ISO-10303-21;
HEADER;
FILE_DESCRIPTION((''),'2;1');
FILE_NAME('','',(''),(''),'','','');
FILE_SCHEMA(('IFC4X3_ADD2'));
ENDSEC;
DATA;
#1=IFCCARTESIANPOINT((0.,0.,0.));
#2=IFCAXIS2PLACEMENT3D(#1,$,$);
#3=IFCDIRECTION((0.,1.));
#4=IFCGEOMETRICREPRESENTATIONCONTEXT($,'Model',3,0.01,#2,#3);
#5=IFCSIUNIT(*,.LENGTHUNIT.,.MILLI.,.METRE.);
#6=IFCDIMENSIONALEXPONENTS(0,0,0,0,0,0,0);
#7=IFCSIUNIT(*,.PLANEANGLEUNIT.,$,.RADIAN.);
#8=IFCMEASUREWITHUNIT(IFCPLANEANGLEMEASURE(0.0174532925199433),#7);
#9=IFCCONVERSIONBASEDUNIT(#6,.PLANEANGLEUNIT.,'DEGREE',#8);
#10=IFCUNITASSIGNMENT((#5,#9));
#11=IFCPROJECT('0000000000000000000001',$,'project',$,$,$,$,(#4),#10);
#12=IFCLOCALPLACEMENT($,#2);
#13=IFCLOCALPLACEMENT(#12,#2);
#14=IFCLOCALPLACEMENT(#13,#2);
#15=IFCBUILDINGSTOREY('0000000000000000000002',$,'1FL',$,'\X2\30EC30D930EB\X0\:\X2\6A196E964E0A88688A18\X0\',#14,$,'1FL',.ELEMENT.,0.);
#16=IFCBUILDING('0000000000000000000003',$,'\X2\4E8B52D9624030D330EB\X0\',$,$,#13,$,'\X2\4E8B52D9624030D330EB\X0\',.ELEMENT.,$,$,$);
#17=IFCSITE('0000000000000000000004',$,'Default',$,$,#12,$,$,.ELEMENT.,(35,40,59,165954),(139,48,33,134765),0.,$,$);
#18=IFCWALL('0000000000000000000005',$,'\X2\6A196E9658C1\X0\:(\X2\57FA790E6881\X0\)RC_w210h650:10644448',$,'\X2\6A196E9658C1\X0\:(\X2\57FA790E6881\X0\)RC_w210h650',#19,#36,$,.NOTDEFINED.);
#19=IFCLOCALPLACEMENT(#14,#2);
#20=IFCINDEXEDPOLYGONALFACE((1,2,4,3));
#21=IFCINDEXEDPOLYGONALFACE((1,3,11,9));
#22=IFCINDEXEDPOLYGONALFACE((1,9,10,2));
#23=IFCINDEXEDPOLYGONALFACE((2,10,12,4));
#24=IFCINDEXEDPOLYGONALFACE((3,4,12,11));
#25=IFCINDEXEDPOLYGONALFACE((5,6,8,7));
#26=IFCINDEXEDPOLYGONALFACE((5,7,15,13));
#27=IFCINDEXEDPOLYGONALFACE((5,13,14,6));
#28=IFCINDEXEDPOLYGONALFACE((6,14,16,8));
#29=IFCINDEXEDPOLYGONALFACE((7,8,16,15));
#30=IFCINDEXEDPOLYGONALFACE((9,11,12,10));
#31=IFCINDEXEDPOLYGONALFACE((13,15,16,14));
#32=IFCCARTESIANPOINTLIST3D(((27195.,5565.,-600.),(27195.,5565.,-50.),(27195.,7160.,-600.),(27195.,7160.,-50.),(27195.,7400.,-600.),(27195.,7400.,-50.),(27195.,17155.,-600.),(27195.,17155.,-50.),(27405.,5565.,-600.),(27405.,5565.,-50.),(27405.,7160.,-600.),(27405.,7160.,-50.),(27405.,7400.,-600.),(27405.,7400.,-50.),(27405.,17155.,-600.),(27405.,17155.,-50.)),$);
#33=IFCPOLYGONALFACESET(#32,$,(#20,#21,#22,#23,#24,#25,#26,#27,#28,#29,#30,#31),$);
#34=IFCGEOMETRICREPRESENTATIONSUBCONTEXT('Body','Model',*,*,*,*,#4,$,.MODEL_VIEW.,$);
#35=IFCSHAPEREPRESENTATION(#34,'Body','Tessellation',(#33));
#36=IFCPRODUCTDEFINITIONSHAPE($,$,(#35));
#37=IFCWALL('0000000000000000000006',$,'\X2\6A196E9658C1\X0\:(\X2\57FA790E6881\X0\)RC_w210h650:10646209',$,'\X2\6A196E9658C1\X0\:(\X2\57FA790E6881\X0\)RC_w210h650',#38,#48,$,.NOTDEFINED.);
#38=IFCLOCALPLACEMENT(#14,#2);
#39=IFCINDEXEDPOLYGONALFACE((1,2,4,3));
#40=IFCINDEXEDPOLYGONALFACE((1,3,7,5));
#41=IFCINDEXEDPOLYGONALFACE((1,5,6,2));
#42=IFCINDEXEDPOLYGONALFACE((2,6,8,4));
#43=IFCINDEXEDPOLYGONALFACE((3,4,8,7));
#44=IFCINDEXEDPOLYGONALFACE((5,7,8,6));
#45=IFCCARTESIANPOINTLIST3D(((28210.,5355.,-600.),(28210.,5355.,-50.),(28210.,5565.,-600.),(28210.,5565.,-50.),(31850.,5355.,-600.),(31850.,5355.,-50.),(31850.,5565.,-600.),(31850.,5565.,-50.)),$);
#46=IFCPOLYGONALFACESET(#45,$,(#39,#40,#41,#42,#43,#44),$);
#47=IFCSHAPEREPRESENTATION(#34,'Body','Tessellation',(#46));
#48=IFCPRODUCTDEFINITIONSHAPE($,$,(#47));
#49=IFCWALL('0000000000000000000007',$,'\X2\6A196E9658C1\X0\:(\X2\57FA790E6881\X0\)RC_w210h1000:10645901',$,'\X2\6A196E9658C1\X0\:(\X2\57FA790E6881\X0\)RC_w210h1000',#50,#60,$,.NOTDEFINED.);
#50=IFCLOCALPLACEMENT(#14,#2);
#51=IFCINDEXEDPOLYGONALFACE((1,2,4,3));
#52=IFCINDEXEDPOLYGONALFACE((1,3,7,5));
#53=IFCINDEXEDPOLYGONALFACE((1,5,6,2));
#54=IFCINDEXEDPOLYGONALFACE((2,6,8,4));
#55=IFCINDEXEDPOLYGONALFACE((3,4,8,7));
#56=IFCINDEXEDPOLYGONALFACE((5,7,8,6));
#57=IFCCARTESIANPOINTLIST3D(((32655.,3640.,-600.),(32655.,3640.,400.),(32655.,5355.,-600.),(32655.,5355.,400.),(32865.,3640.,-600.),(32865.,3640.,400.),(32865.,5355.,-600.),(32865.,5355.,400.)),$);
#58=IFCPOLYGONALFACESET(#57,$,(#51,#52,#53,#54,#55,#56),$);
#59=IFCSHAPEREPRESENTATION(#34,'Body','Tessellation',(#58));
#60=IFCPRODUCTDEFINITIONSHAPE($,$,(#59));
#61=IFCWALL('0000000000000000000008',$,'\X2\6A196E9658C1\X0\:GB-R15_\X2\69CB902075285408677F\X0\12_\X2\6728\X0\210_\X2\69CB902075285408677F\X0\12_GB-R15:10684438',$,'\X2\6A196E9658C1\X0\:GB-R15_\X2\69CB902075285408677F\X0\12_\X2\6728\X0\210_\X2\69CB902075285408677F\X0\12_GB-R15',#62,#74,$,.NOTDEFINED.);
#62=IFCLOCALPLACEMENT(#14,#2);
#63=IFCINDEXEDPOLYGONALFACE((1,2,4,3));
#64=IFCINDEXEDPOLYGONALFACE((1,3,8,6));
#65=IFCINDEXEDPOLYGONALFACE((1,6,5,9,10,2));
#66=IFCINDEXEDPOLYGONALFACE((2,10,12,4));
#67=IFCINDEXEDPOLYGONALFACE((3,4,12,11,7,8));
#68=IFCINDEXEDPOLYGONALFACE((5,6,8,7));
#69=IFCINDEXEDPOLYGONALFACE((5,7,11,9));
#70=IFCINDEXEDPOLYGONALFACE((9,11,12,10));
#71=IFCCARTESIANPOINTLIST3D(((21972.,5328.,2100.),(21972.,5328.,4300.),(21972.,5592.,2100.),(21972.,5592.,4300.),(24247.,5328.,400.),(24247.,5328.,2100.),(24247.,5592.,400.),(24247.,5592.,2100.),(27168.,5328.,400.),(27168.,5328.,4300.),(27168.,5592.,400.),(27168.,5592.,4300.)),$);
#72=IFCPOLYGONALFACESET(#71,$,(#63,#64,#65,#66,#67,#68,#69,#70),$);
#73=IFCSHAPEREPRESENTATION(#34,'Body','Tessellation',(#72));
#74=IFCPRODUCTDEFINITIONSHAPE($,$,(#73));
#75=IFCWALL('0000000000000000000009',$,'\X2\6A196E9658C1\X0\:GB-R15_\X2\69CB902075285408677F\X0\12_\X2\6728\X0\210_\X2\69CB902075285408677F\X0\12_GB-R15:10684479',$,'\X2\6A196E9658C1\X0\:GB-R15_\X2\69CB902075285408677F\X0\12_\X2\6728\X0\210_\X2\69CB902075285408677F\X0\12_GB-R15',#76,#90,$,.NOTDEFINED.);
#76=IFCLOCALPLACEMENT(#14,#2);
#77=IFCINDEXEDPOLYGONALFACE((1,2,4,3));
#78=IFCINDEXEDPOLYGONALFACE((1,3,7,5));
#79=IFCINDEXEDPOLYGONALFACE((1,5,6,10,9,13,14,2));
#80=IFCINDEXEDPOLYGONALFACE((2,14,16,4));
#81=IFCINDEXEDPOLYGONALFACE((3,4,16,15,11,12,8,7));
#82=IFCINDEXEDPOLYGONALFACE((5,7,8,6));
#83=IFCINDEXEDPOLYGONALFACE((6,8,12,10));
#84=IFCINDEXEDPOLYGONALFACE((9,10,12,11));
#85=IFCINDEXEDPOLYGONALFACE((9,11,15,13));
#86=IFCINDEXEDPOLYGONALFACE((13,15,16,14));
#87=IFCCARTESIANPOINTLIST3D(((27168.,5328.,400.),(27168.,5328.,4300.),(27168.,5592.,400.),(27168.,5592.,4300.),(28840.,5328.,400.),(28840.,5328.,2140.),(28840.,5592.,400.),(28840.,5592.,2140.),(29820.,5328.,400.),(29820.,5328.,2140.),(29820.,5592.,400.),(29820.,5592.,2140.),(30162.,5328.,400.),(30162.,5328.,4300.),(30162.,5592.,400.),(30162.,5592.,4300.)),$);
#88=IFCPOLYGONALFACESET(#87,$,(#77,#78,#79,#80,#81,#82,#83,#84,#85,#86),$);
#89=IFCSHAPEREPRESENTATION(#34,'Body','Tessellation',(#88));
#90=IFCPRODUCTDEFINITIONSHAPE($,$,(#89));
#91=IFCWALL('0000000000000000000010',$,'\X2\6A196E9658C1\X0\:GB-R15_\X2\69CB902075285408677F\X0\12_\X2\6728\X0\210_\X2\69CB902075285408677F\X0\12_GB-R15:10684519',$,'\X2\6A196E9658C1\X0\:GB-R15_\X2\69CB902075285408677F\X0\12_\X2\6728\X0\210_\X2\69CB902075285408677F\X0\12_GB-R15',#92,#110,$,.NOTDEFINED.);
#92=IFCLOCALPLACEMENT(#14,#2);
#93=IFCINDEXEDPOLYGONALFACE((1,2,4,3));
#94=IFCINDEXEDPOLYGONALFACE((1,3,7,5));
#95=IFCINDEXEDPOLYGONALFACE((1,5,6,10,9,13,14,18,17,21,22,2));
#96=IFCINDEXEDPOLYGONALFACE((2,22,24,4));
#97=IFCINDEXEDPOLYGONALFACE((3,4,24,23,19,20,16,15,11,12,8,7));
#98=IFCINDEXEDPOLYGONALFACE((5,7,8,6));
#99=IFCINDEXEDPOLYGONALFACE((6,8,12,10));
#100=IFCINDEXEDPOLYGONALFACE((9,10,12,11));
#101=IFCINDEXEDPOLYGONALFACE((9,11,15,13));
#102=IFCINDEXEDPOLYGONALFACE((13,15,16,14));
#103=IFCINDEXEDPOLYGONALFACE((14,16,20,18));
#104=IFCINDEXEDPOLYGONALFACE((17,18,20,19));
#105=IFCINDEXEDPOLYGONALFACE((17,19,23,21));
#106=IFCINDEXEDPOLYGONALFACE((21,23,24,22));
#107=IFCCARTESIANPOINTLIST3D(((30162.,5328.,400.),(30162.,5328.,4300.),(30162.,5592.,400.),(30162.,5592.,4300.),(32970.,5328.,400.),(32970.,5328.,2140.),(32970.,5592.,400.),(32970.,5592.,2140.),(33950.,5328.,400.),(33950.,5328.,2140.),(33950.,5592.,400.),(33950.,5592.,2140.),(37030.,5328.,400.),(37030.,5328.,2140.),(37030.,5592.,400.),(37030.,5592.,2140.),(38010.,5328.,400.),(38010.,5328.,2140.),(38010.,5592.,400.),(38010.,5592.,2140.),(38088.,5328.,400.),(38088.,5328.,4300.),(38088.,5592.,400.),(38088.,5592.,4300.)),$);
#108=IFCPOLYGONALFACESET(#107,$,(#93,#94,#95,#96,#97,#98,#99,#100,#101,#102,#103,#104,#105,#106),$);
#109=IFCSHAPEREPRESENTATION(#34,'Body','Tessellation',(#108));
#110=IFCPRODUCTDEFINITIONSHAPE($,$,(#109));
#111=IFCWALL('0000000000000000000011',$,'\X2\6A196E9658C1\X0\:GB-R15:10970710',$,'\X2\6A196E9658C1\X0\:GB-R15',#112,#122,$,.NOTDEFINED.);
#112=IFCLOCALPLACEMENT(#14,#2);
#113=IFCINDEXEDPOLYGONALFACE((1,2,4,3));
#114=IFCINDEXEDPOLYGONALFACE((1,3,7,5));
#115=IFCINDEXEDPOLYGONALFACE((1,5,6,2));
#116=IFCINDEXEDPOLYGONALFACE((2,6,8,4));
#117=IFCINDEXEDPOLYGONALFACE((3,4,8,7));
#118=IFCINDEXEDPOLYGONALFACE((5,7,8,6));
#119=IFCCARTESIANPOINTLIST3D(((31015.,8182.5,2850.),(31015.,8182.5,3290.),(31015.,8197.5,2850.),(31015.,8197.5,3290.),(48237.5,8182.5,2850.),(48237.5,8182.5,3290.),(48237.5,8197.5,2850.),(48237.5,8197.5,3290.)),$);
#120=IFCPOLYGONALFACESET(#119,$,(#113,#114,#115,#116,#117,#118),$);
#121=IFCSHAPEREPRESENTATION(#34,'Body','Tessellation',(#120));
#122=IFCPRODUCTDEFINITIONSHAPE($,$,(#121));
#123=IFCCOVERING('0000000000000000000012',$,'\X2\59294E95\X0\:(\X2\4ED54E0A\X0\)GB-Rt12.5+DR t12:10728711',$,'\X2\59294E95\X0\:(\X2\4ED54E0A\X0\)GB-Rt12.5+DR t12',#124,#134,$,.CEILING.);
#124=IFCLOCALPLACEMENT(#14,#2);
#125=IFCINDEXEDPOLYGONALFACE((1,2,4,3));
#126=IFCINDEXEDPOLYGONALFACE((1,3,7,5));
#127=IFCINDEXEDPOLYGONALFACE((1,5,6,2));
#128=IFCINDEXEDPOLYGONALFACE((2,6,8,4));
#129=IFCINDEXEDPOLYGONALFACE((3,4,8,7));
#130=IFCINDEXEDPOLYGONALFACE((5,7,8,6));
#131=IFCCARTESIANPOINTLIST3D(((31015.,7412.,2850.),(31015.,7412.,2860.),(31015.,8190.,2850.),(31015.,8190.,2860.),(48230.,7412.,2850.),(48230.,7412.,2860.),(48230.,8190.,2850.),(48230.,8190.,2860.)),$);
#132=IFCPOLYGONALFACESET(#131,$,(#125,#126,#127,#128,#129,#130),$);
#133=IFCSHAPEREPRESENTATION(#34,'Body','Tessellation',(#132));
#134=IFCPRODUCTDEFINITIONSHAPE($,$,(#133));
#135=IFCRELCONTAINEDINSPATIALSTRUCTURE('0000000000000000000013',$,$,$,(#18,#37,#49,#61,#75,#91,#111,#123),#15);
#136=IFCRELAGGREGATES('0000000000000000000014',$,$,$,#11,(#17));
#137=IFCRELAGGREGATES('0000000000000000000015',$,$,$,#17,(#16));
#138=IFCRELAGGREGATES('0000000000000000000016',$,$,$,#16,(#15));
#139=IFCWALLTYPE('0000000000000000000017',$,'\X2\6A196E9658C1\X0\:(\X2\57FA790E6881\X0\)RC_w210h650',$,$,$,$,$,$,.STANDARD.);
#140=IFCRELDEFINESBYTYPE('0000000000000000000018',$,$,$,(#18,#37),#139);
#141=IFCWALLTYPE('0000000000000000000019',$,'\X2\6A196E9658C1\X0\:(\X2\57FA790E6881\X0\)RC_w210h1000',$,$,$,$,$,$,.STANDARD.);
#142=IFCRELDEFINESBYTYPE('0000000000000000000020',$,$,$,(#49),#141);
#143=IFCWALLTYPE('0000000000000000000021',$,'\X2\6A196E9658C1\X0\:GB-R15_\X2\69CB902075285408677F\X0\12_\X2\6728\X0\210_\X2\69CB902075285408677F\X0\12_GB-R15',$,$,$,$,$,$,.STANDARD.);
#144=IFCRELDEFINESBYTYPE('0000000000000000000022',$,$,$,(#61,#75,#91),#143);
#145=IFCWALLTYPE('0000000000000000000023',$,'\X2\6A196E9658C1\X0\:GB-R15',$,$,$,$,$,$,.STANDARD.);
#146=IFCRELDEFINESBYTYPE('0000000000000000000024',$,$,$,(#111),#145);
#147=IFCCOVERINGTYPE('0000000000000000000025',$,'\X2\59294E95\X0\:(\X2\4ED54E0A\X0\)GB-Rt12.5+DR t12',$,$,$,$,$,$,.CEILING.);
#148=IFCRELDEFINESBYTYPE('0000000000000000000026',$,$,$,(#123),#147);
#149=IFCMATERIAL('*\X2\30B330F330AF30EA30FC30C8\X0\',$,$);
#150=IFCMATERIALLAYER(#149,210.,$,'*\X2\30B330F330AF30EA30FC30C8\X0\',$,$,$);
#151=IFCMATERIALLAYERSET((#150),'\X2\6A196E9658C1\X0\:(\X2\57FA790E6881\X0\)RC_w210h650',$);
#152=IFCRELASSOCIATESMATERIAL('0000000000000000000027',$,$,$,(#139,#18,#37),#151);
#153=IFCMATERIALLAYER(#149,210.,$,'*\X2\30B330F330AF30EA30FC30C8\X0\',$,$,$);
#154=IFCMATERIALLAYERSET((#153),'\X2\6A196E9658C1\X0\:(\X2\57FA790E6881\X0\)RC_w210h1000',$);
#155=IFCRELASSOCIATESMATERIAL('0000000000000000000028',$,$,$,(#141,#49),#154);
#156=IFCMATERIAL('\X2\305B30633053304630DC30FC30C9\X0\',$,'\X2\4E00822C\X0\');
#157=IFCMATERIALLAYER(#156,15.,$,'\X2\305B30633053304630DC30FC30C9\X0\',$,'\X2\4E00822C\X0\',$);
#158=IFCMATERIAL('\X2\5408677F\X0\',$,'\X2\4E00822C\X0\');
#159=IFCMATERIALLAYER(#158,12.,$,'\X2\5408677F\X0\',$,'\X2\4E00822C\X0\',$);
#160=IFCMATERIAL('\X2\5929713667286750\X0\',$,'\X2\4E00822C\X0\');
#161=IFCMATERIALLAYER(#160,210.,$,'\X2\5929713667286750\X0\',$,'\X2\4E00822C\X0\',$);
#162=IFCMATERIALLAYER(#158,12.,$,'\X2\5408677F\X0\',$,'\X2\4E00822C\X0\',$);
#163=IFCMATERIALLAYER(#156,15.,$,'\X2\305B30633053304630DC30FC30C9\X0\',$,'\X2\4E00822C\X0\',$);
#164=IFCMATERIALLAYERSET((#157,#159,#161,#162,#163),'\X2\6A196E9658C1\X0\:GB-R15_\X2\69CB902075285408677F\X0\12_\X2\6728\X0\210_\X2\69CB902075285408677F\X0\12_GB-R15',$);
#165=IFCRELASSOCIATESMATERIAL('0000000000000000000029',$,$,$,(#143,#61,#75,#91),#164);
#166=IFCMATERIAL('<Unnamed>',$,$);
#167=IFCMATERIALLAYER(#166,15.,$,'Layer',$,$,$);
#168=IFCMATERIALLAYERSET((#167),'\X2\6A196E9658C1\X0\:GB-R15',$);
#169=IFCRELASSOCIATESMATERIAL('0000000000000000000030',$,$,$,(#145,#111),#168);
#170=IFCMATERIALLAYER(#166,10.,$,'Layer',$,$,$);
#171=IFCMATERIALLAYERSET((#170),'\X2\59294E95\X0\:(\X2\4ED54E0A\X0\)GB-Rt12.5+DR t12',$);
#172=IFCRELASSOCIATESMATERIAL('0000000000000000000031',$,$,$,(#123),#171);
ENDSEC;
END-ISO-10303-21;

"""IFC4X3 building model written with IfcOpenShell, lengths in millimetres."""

from ifc_helpers import new_model, entity, si_unit, converted_unit, direction, frame, frame_2d, origin, place, context, subcontext, project, spatial, rectangle, extrude, material, layer, layer_set, layer_usage, type_object, element, save


model = new_model("IFC4X3")

# Units and contexts
model_context = context("Model", 3, precision=0.01, world=origin(), true_north=direction((0.0, 1.0)))
body_context = subcontext(model_context, "Body", "Model", "MODEL_VIEW")
ifc_project = project(units=[si_unit("LENGTHUNIT", "METRE", prefix="MILLI"), converted_unit("PLANEANGLEUNIT", "DEGREE", entity("IfcPlaneAngleMeasure", 0.0174532925199433), si_unit("PLANEANGLEUNIT", "RADIAN"), dimensions=[0, 0, 0, 0, 0, 0, 0])], contexts=[model_context])

# Site, building, storey
site_placement = place(None, origin())
site = spatial("IfcSite", under=ifc_project, at=site_placement, Name="Default", CompositionType="ELEMENT", RefLatitude=(35, 40, 59, 165954), RefLongitude=(139, 48, 33, 134765), RefElevation=0.0)
building_placement = place(site_placement, origin())
building = spatial("IfcBuilding", under=site, at=building_placement, Name="事務所ビル", LongName="事務所ビル", CompositionType="ELEMENT")
storey_placement = place(building_placement, origin())
storey = spatial("IfcBuildingStorey", under=building, at=storey_placement, Name="1FL", ObjectType="レベル:標準上表記", LongName="1FL", CompositionType="ELEMENT", Elevation=0.0)

# Shared definitions
ifc_material_1 = material(Name="*コンクリート")
ifc_material_2 = material(Name="<Unnamed>")

# Wall, opening
ifc_layer_1 = layer(ifc_material_1, 210.0, Name="*コンクリート")
ifc_layer_set_1 = layer_set([ifc_layer_1], Name="標準壁:(基礎梁)RC_w210h650")
wall_type_1 = type_object("IfcWallType", Name="標準壁:(基礎梁)RC_w210h650", PredefinedType="STANDARD", material=ifc_layer_set_1)
wall_1_placement = place(storey_placement, frame((27300.0, 5565.0, -600.0), z_axis=(0.0, 0.0, 1.0), x_axis=(0.0, 1.0, 0.0)))
wall_1 = element("IfcWall", 1, at=wall_1_placement, inside=storey, type_object=wall_type_1, material=ifc_layer_set_1, Name="標準壁:(基礎梁)RC_w210h650:10644448", ObjectType="標準壁:(基礎梁)RC_w210h650", PredefinedType="NOTDEFINED", context=body_context, shape_type="SweptSolid", body=[
    extrude(rectangle(XDim=11590.0, YDim=210.0, at=frame_2d((5795.0, 0.0), x_axis=(-1.0, 0.0))), origin(), (0.0, 0.0, 1.0), 550.0),
])
opening_1_placement = place(storey_placement, frame((27300.0, 5565.0, -600.0), z_axis=(0.0, 0.0, 1.0), x_axis=(0.0, 1.0, 0.0)))
element("IfcOpeningElement", 2, at=opening_1_placement, cuts=wall_1, PredefinedType="OPENING", context=body_context, shape_type="SweptSolid", body=[
    extrude(rectangle(XDim=550.0, YDim=210.0, at=frame_2d((0.0, 0.0), x_axis=(1.0, 0.0))), frame((1595.0, 0.0, 275.0), z_axis=(1.0, 0.0, 0.0), x_axis=(0.0, 0.0, -1.0)), (0.0, 0.0, 1.0), 240.0),
])

# Wall
wall_2_placement = place(storey_placement, frame((28210.0, 5460.0, -600.0)))
element("IfcWall", 3, at=wall_2_placement, inside=storey, type_object=wall_type_1, material=ifc_layer_set_1, Name="標準壁:(基礎梁)RC_w210h650:10646209", ObjectType="標準壁:(基礎梁)RC_w210h650", PredefinedType="NOTDEFINED", context=body_context, shape_type="SweptSolid", body=[
    extrude(rectangle(XDim=3640.0, YDim=210.0, at=frame_2d((1820.0, 0.0), x_axis=(-1.0, 0.0))), origin(), (0.0, 0.0, 1.0), 550.0),
])

# Shared definitions
ifc_layer_2 = layer(ifc_material_1, 210.0, Name="*コンクリート")
ifc_layer_set_2 = layer_set([ifc_layer_2], Name="標準壁:(基礎梁)RC_w210h1000")
wall_type_2 = type_object("IfcWallType", Name="標準壁:(基礎梁)RC_w210h1000", PredefinedType="STANDARD", material=ifc_layer_set_2)

# Wall
wall_3_placement = place(storey_placement, frame((32760.0, 5355.0, -600.0), z_axis=(0.0, 0.0, 1.0), x_axis=(0.0, -1.0, 0.0)))
element("IfcWall", 4, at=wall_3_placement, inside=storey, type_object=wall_type_2, material=ifc_layer_set_2, Name="標準壁:(基礎梁)RC_w210h1000:10645901", ObjectType="標準壁:(基礎梁)RC_w210h1000", PredefinedType="NOTDEFINED", context=body_context, shape_type="SweptSolid", body=[
    extrude(rectangle(XDim=1715.0, YDim=210.0, at=frame_2d((857.5, 0.0), x_axis=(-1.0, 0.0))), origin(), (0.0, 0.0, 1.0), 1000.0),
])

# Wall, openings
ifc_material_3 = material(Name="せっこうボード", Category="一般")
ifc_layer_3 = layer(ifc_material_3, 15.0, Name="せっこうボード", Category="一般")
ifc_material_4 = material(Name="合板", Category="一般")
ifc_layer_4 = layer(ifc_material_4, 12.0, Name="合板", Category="一般")
ifc_material_5 = material(Name="天然木材", Category="一般")
ifc_layer_5 = layer(ifc_material_5, 210.0, Name="天然木材", Category="一般")
ifc_layer_6 = layer(ifc_material_4, 12.0, Name="合板", Category="一般")
ifc_layer_7 = layer(ifc_material_3, 15.0, Name="せっこうボード", Category="一般")
ifc_layer_set_3 = layer_set([ifc_layer_3, ifc_layer_4, ifc_layer_5, ifc_layer_6, ifc_layer_7], Name="標準壁:GB-R15_構造用合板12_木210_構造用合板12_GB-R15")
wall_type_3 = type_object("IfcWallType", Name="標準壁:GB-R15_構造用合板12_木210_構造用合板12_GB-R15", PredefinedType="STANDARD", material=ifc_layer_set_3)
wall_4_placement = place(storey_placement, frame((21972.0, 5460.0, 400.0)))
wall_4 = element("IfcWall", 5, at=wall_4_placement, inside=storey, type_object=wall_type_3, material=ifc_layer_set_3, Name="標準壁:GB-R15_構造用合板12_木210_構造用合板12_GB-R15:10684438", ObjectType="標準壁:GB-R15_構造用合板12_木210_構造用合板12_GB-R15", PredefinedType="NOTDEFINED", context=body_context, shape_type="SweptSolid", body=[
    extrude(rectangle(XDim=5196.0, YDim=264.0, at=frame_2d((2598.0, 0.0), x_axis=(-1.0, 0.0))), origin(), (0.0, 0.0, 1.0), 3900.0),
])
opening_2_placement = place(wall_4_placement, frame((-21972.0, -5460.0, 3900.0)))
element("IfcOpeningElement", 6, at=opening_2_placement, cuts=wall_4, PredefinedType="OPENING", context=body_context, shape_type="SweptSolid", body=[
    extrude(rectangle(XDim=2100.0, YDim=2275.0, at=frame_2d((0.0, 0.0), x_axis=(0.0, 1.0))), frame((23109.5, 3804.0, 1050.0), z_axis=(0.0, 1.0, 0.0), x_axis=(1.0, 0.0, 0.0)), (0.0, 0.0, 1.0), 3048.0),
])
opening_3_placement = place(wall_4_placement, frame((0.0, -132.0, -400.0)))
element("IfcOpeningElement", 7, at=opening_3_placement, cuts=wall_4, PredefinedType="OPENING", context=body_context, shape_type="SweptSolid", body=[
    extrude(rectangle(XDim=2100.0, YDim=2275.0, at=frame_2d((1050.0, 1137.5), x_axis=(-1.0, 0.0))), frame((0.0, 0.0, 0.0), z_axis=(0.0, 1.0, 0.0), x_axis=(0.0, 0.0, 1.0)), (0.0, 0.0, 1.0), 264.0),
])

# Wall, opening
wall_5_placement = place(storey_placement, frame((27168.0, 5460.0, 400.0)))
wall_5 = element("IfcWall", 8, at=wall_5_placement, inside=storey, type_object=wall_type_3, material=ifc_layer_set_3, Name="標準壁:GB-R15_構造用合板12_木210_構造用合板12_GB-R15:10684479", ObjectType="標準壁:GB-R15_構造用合板12_木210_構造用合板12_GB-R15", PredefinedType="NOTDEFINED", context=body_context, shape_type="SweptSolid", body=[
    extrude(rectangle(XDim=2994.0, YDim=264.0, at=frame_2d((1497.0, 0.0), x_axis=(-1.0, 0.0))), origin(), (0.0, 0.0, 1.0), 3900.0),
])
opening_4_placement = place(wall_5_placement, frame((1672.0, -132.0, -400.0)))
element("IfcOpeningElement", 9, at=opening_4_placement, cuts=wall_5, PredefinedType="OPENING", context=body_context, shape_type="SweptSolid", body=[
    extrude(rectangle(XDim=2140.0, YDim=980.0, at=frame_2d((1070.0, 490.0), x_axis=(-1.0, 0.0))), frame((0.0, 0.0, 0.0), z_axis=(0.0, 1.0, 0.0), x_axis=(0.0, 0.0, 1.0)), (0.0, 0.0, 1.0), 264.0),
])

# Wall, openings
wall_6_placement = place(storey_placement, frame((30162.0, 5460.0, 400.0)))
wall_6 = element("IfcWall", 10, at=wall_6_placement, inside=storey, type_object=wall_type_3, material=ifc_layer_set_3, Name="標準壁:GB-R15_構造用合板12_木210_構造用合板12_GB-R15:10684519", ObjectType="標準壁:GB-R15_構造用合板12_木210_構造用合板12_GB-R15", PredefinedType="NOTDEFINED", context=body_context, shape_type="SweptSolid", body=[
    extrude(rectangle(XDim=7926.0, YDim=264.0, at=frame_2d((3963.0, 0.0), x_axis=(-1.0, 0.0))), origin(), (0.0, 0.0, 1.0), 3900.0),
])
opening_5_placement = place(wall_6_placement, frame((-30162.0, -5460.0, 3900.0)))
element("IfcOpeningElement", 11, at=opening_5_placement, cuts=wall_6, PredefinedType="OPENING", context=body_context, shape_type="SweptSolid", body=[
    extrude(rectangle(XDim=2140.0, YDim=980.0, at=frame_2d((0.0, 0.0), x_axis=(0.0, 1.0))), frame((33460.0, 4068.0, 1070.0), z_axis=(0.0, 1.0, 0.0), x_axis=(1.0, 0.0, 0.0)), (0.0, 0.0, 1.0), 3048.0),
])
opening_6_placement = place(wall_6_placement, frame((-30162.0, -5460.0, 3900.0)))
element("IfcOpeningElement", 12, at=opening_6_placement, cuts=wall_6, PredefinedType="OPENING", context=body_context, shape_type="SweptSolid", body=[
    extrude(rectangle(XDim=2140.0, YDim=980.0, at=frame_2d((0.0, 0.0), x_axis=(1.0, 0.0))), frame((37520.0, 4068.0, 1070.0), z_axis=(0.0, 1.0, 0.0), x_axis=(0.0, 0.0, -1.0)), (0.0, 0.0, 1.0), 3048.0),
])
opening_7_placement = place(wall_6_placement, frame((3788.0, 132.0, -400.0)))
element("IfcOpeningElement", 13, at=opening_7_placement, cuts=wall_6, PredefinedType="OPENING", context=body_context, shape_type="SweptSolid", body=[
    extrude(rectangle(XDim=2140.0, YDim=980.0, at=frame_2d((1070.0, 490.0), x_axis=(-1.0, 0.0))), frame((0.0, 0.0, 0.0), z_axis=(0.0, -1.0, 0.0), x_axis=(0.0, 0.0, 1.0)), (0.0, 0.0, 1.0), 264.0),
])
opening_8_placement = place(wall_6_placement, frame((7848.0, 132.0, -400.0)))
element("IfcOpeningElement", 14, at=opening_8_placement, cuts=wall_6, PredefinedType="OPENING", context=body_context, shape_type="SweptSolid", body=[
    extrude(rectangle(XDim=2140.0, YDim=980.0, at=frame_2d((1070.0, 490.0), x_axis=(-1.0, 0.0))), frame((0.0, 0.0, 0.0), z_axis=(0.0, -1.0, 0.0), x_axis=(0.0, 0.0, 1.0)), (0.0, 0.0, 1.0), 264.0),
])

# Wall
ifc_layer_8 = layer(ifc_material_2, 15.0, Name="Layer")
ifc_layer_set_4 = layer_set([ifc_layer_8], Name="標準壁:GB-R15")
wall_type_4 = type_object("IfcWallType", Name="標準壁:GB-R15", PredefinedType="STANDARD", material=ifc_layer_set_4)
wall_7_placement = place(storey_placement, frame((31015.0, 8190.0, 2850.0)))
element("IfcWall", 15, at=wall_7_placement, inside=storey, type_object=wall_type_4, material=ifc_layer_set_4, Name="標準壁:GB-R15:10970710", ObjectType="標準壁:GB-R15", PredefinedType="NOTDEFINED", context=body_context, shape_type="SweptSolid", body=[
    extrude(rectangle(XDim=17222.5, YDim=15.0, at=frame_2d((8611.2, 0.0), x_axis=(-1.0, 0.0))), origin(), (0.0, 0.0, 1.0), 440.0),
])

# Covering
ifc_layer_9 = layer(ifc_material_2, 10.0, Name="Layer")
ifc_layer_set_5 = layer_set([ifc_layer_9], Name="天井:(仕上)GB-Rt12.5+DR t12")
covering_type = type_object("IfcCoveringType", Name="天井:(仕上)GB-Rt12.5+DR t12", PredefinedType="CEILING")
ifc_layer_usage_1 = layer_usage(ifc_layer_set_5, "AXIS3", "NEGATIVE", 0.0)
covering_1_placement = place(storey_placement, frame((31015.0, 7412.0, 2850.0)))
element("IfcCovering", 16, at=covering_1_placement, inside=storey, type_object=covering_type, material=ifc_layer_usage_1, Name="天井:(仕上)GB-Rt12.5+DR t12:10728711", ObjectType="天井:(仕上)GB-Rt12.5+DR t12", PredefinedType="CEILING", context=body_context, shape_type="SweptSolid", body=[
    extrude(rectangle(XDim=17215.0, YDim=778.0, at=frame_2d((0.0, 0.0), x_axis=(1.0, 0.0))), frame((8607.5, 389.0, 0.0), z_axis=(0.0, 0.0, 1.0), x_axis=(-1.0, 0.0, 0.0)), (0.0, 0.0, 1.0), 10.0),
])

save(model, "model.ifc")
